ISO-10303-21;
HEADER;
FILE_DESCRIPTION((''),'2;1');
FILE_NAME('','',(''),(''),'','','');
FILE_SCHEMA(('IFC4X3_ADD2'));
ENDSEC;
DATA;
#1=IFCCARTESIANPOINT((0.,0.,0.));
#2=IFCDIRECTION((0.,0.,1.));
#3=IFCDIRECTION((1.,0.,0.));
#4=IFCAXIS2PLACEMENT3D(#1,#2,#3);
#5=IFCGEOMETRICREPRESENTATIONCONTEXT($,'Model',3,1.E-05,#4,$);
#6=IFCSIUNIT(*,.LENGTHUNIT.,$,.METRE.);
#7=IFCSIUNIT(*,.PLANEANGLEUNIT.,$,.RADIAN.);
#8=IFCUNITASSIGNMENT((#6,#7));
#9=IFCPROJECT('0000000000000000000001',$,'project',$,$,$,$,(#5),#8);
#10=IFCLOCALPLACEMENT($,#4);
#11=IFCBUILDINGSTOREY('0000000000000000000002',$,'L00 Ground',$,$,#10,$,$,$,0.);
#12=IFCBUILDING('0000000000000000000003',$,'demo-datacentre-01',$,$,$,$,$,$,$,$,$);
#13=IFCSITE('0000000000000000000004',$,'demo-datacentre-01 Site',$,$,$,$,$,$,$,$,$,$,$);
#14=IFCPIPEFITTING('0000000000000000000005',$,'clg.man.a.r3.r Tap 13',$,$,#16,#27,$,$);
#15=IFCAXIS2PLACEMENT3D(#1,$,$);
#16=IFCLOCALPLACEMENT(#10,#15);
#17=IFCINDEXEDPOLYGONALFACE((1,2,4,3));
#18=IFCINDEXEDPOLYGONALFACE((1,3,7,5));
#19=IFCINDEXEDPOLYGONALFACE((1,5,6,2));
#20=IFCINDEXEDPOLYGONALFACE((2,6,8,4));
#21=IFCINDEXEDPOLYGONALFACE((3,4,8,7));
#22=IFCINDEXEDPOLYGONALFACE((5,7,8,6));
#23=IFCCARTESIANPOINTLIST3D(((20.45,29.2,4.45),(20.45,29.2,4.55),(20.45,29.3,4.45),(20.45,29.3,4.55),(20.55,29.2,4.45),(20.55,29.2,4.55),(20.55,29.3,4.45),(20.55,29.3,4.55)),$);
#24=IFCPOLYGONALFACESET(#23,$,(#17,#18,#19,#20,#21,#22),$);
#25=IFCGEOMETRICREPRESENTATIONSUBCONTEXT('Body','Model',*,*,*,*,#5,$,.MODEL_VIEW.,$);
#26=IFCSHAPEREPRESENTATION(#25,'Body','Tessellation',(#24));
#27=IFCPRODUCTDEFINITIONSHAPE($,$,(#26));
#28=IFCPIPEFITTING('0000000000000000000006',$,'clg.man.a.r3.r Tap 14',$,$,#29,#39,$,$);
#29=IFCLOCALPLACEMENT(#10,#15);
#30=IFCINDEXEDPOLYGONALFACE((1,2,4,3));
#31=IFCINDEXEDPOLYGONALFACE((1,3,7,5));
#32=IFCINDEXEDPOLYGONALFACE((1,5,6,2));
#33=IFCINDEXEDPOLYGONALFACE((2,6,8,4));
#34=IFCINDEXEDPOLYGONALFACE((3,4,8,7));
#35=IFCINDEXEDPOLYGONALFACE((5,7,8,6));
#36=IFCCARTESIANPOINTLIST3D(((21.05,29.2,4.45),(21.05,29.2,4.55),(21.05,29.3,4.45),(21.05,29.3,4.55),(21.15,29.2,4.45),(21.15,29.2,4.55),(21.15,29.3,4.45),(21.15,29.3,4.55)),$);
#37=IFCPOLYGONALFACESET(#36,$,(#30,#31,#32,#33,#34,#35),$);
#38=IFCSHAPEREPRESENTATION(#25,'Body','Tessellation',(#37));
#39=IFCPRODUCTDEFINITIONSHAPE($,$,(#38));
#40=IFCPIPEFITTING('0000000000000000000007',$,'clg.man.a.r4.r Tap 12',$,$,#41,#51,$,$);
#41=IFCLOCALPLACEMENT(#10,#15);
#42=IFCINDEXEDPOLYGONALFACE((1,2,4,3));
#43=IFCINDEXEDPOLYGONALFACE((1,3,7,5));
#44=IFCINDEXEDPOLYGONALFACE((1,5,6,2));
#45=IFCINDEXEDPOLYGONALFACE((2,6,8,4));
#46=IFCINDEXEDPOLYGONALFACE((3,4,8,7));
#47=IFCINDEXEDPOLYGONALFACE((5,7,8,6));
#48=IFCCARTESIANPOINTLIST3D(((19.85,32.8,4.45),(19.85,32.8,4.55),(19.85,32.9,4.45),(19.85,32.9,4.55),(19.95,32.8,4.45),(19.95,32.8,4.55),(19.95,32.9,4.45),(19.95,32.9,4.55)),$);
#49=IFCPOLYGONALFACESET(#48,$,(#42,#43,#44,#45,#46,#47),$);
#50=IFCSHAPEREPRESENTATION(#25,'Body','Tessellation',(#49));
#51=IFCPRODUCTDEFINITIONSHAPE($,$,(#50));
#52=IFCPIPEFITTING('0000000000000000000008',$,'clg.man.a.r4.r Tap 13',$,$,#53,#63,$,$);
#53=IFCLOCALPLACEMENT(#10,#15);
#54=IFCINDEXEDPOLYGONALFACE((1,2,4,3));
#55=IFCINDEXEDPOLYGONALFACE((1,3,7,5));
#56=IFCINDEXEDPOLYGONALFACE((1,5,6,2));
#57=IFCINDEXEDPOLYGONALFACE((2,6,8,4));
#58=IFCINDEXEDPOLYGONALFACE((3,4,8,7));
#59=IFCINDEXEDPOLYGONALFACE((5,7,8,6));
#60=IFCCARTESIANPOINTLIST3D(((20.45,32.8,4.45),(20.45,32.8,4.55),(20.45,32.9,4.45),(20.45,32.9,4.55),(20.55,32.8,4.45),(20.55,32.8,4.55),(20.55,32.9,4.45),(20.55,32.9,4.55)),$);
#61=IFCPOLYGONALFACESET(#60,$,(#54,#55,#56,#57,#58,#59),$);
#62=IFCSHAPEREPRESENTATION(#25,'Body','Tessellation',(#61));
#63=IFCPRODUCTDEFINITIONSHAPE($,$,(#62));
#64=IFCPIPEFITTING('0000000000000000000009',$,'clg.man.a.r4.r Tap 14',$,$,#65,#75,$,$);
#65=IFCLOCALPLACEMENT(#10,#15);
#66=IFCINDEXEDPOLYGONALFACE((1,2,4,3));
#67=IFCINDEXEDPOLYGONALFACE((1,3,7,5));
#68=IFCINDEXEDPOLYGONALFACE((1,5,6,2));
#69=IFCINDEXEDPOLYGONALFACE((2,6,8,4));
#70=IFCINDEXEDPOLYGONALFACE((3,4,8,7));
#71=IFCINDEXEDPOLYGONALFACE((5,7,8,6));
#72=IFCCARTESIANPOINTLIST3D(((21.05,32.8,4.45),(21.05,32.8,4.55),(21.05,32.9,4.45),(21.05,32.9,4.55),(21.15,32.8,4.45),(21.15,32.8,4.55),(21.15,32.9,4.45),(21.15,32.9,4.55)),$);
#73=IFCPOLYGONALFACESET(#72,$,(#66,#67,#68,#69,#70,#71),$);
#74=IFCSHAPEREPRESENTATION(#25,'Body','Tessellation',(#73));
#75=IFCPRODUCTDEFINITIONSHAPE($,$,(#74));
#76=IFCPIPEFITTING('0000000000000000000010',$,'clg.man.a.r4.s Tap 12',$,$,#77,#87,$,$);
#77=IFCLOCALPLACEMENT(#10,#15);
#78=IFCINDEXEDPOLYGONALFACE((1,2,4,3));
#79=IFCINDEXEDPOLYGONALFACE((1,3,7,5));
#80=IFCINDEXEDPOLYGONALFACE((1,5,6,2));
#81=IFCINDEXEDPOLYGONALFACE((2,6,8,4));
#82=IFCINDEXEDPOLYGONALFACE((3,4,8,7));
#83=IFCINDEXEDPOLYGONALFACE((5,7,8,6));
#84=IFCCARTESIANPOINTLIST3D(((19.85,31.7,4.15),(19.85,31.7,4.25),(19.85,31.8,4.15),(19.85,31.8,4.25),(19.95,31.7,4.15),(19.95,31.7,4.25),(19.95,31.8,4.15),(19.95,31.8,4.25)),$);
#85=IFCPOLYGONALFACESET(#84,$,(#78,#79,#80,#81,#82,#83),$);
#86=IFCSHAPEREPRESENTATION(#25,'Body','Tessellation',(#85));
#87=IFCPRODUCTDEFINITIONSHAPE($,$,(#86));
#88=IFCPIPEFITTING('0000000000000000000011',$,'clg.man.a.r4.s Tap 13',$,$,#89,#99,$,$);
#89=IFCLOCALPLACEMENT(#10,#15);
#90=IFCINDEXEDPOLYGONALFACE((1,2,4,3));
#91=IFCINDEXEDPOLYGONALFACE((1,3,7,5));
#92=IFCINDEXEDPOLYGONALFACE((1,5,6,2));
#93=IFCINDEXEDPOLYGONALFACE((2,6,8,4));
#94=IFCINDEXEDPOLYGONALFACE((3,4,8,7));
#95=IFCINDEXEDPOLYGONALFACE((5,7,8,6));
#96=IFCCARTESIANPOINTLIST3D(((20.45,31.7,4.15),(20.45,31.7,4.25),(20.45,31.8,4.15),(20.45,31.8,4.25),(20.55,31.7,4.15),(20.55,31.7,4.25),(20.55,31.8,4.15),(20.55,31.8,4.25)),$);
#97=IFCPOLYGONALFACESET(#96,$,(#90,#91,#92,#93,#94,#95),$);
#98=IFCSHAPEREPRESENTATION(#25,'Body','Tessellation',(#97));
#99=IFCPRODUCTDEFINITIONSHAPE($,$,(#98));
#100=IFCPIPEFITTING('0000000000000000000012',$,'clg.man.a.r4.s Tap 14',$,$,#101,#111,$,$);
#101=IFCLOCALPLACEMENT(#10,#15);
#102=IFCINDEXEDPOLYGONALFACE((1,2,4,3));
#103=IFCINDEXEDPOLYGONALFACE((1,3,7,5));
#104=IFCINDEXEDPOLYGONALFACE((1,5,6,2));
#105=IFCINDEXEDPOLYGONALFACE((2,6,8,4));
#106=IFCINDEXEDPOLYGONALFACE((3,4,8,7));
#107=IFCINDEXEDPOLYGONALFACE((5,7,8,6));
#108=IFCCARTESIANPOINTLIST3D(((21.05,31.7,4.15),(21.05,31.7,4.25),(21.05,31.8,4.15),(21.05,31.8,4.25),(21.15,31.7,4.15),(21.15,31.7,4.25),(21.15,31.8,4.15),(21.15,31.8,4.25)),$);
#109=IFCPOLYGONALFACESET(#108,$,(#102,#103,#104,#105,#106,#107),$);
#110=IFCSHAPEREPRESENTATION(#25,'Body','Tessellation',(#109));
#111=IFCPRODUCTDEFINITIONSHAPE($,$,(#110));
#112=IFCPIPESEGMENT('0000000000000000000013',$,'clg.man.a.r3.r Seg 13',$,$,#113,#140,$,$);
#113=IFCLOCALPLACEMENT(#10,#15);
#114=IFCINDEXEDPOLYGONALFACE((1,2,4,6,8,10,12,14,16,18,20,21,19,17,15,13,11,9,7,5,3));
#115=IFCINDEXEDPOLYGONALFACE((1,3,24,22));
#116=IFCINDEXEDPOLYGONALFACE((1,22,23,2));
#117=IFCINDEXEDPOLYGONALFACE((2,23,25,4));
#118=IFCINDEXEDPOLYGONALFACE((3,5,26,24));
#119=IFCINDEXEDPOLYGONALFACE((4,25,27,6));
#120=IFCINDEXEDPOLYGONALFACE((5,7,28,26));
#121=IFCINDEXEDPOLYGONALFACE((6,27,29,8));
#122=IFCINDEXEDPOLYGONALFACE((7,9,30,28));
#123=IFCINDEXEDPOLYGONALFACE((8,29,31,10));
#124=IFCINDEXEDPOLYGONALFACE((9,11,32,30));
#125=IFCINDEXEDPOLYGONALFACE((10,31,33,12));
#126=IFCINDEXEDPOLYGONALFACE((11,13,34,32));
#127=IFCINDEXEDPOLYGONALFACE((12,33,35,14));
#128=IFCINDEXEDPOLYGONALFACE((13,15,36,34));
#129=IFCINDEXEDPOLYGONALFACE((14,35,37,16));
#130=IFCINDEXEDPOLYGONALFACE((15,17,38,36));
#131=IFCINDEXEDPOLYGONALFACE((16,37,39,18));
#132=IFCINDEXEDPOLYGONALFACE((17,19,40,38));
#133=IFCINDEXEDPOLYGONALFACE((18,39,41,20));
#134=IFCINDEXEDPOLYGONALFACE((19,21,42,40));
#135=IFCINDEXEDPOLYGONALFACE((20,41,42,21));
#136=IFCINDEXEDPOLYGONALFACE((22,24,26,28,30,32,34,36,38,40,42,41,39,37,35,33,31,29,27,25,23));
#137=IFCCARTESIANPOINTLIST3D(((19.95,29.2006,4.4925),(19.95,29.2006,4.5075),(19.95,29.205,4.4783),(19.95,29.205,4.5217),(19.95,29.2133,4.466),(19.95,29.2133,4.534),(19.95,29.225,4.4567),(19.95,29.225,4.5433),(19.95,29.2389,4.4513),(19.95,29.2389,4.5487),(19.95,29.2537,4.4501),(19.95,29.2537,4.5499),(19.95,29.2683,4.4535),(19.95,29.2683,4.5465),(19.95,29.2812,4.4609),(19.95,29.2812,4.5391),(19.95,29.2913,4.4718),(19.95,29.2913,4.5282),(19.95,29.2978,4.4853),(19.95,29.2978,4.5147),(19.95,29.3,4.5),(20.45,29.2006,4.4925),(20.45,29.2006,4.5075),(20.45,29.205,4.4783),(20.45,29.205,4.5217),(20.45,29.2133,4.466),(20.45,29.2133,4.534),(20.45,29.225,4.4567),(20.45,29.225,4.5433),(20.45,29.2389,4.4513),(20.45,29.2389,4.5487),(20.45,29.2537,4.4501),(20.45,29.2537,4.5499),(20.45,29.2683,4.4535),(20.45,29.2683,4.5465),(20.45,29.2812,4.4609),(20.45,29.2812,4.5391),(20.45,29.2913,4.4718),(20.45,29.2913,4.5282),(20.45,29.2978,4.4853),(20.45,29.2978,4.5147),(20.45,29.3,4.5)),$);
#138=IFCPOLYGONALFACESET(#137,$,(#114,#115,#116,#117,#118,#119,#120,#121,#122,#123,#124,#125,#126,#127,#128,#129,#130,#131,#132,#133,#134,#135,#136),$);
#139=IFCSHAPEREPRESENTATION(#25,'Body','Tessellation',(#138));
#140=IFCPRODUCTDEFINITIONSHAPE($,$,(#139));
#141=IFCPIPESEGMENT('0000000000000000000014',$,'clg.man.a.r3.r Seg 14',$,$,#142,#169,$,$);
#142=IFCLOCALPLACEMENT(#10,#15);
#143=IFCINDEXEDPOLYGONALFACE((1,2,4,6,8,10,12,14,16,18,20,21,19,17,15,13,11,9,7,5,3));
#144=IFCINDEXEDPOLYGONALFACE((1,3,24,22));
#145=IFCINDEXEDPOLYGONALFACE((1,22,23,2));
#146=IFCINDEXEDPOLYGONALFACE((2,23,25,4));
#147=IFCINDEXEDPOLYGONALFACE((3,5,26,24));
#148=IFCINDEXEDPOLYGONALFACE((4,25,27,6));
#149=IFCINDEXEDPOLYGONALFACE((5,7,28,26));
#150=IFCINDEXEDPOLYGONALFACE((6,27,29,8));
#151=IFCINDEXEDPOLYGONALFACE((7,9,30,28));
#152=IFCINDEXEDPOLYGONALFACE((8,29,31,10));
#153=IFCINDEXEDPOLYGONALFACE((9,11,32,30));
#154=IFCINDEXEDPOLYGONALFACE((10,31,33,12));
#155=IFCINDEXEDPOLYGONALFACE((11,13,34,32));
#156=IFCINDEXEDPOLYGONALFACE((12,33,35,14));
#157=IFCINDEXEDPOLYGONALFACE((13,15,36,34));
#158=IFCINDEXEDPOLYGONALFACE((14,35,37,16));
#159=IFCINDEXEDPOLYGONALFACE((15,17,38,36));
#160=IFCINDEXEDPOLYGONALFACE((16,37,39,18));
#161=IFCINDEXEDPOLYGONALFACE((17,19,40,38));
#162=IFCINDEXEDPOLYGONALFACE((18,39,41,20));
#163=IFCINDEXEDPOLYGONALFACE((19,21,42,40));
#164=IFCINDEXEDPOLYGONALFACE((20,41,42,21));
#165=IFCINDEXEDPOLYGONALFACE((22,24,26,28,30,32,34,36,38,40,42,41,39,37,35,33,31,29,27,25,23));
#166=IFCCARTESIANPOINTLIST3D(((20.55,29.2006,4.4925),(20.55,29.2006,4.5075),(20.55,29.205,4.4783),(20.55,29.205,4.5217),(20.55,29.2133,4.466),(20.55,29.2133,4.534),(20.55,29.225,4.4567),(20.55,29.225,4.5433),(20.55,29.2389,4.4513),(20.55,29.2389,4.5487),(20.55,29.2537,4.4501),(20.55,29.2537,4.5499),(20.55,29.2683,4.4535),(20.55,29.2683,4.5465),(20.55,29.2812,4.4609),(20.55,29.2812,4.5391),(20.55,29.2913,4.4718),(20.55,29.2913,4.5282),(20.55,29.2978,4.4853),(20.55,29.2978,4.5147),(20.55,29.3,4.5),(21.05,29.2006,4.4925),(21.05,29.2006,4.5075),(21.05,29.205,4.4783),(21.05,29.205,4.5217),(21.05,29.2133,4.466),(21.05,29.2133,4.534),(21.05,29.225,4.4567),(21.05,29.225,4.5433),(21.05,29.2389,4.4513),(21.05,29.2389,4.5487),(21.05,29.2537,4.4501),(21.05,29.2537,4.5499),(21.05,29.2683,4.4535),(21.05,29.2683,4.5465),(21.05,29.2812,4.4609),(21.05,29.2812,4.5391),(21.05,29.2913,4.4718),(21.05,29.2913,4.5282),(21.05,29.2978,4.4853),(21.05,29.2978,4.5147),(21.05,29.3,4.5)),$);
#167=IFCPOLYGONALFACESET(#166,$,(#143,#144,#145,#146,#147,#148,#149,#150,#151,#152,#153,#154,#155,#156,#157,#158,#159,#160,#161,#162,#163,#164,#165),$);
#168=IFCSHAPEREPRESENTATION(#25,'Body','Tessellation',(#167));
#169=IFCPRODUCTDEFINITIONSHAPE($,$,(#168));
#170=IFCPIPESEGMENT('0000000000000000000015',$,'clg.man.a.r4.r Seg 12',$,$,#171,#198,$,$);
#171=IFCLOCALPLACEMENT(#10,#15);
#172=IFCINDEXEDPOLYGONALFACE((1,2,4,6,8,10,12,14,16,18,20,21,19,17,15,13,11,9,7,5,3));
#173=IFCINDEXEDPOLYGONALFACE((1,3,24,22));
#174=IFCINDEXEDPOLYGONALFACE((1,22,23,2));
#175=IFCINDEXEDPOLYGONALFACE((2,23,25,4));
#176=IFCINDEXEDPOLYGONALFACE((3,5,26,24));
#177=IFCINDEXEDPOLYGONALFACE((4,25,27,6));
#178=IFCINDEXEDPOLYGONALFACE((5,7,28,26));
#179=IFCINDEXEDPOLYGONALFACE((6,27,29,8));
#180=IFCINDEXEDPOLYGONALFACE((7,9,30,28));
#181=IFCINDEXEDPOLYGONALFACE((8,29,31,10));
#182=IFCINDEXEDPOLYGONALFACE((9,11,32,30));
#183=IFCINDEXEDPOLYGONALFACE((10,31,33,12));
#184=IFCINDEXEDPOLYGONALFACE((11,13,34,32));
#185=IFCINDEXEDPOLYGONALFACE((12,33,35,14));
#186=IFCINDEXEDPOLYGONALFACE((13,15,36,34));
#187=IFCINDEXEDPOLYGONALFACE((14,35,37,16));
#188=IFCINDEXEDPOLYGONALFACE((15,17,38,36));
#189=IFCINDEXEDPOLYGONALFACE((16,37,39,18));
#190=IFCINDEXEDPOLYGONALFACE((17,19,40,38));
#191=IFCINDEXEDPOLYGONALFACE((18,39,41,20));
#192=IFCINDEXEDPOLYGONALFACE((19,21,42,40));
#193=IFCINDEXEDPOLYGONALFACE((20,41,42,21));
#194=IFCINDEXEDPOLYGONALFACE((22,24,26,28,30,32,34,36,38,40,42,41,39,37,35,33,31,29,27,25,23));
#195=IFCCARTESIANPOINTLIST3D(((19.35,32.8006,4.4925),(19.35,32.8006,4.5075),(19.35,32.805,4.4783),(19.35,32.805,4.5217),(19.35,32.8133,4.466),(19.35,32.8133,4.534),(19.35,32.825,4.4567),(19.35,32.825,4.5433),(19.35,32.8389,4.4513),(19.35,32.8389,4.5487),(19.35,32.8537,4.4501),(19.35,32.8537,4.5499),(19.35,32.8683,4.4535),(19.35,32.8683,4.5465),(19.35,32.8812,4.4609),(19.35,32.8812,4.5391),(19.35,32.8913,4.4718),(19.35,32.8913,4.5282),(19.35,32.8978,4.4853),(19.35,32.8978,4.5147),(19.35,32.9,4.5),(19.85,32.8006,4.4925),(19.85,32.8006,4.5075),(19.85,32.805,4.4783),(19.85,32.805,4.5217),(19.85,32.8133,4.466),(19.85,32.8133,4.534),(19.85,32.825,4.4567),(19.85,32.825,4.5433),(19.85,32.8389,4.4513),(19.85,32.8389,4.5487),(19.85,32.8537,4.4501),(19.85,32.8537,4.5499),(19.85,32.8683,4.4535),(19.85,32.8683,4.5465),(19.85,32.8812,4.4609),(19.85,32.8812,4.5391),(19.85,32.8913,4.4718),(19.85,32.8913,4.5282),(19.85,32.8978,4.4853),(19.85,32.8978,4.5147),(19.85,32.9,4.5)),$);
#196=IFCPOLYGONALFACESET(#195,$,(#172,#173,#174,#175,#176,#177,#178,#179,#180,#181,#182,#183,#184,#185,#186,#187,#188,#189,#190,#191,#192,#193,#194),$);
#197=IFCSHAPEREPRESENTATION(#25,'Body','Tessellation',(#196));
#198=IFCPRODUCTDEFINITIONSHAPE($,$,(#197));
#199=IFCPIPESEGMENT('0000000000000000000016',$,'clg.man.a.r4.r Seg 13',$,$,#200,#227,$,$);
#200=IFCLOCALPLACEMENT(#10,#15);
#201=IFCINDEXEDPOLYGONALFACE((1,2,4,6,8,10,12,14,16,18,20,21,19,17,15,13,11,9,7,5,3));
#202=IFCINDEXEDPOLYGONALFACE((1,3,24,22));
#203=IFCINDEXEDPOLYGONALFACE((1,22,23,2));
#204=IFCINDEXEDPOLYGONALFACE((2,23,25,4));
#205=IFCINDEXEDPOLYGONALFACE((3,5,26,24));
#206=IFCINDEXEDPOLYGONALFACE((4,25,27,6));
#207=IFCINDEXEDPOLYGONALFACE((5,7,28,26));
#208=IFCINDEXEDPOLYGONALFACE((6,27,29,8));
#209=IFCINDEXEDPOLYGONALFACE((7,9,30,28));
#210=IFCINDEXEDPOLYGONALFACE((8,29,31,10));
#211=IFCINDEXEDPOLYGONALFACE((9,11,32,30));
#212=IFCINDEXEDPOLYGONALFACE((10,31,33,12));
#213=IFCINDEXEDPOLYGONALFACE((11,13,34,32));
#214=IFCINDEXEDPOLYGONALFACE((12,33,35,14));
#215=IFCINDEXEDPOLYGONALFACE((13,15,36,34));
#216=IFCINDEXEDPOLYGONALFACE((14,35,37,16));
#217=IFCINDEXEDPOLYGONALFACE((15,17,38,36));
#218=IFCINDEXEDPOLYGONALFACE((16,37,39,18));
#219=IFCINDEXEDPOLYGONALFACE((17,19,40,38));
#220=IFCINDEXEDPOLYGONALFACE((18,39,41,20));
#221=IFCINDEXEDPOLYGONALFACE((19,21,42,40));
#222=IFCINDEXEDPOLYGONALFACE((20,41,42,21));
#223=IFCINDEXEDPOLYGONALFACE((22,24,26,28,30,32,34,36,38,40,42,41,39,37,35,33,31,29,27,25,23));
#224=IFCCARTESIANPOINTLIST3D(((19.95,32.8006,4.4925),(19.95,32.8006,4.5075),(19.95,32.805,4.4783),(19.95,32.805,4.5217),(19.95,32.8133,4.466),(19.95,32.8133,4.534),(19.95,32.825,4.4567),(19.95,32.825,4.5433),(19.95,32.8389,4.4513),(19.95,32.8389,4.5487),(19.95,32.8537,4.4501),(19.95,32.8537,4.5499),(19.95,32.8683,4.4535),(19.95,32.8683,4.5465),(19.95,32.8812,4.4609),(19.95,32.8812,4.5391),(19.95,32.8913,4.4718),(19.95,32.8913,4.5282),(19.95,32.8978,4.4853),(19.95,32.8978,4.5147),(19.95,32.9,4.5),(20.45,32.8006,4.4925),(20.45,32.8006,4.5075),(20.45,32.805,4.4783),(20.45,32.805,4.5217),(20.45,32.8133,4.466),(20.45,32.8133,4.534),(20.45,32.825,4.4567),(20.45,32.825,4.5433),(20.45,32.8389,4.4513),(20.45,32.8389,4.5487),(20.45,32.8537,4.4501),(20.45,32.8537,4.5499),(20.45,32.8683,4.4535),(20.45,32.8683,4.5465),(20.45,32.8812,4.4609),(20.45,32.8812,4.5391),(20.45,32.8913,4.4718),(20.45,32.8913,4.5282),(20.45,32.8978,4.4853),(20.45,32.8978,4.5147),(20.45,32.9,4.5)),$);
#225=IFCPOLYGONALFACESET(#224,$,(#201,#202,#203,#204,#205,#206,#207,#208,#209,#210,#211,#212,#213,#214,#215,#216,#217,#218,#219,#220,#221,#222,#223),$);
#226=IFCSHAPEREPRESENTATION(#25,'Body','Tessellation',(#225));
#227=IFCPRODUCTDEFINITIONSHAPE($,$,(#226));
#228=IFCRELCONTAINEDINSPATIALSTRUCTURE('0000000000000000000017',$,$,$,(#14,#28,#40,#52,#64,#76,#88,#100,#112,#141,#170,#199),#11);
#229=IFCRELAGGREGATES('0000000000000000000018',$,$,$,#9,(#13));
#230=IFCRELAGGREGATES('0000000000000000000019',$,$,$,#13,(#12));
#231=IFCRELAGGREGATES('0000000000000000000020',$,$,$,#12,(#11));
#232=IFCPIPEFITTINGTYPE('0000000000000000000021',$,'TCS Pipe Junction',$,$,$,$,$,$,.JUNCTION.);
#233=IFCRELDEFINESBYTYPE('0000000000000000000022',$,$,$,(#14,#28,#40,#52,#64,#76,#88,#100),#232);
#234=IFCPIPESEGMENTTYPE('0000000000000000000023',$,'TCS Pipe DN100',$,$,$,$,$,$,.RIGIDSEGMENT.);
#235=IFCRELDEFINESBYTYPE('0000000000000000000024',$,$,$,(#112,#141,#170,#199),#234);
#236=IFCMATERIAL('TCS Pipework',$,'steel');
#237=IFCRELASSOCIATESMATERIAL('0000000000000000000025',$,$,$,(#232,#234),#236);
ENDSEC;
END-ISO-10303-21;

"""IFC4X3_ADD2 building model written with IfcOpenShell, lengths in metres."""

from ifc_helpers import new_model, si_unit, frame, origin_with_axes, place, context, subcontext, project, spatial, rectangle, circle, extrude, material, type_object, element, save


model = new_model("IFC4X3_ADD2")

# Units and contexts
model_context = context("Model", 3, precision=1e-05, world=origin_with_axes())
body_context = subcontext(model_context, "Body", "Model", "MODEL_VIEW")
ifc_project = project(units=[si_unit("LENGTHUNIT", "METRE"), si_unit("PLANEANGLEUNIT", "RADIAN")], contexts=[model_context])

# Site, building, storey
site = spatial("IfcSite", under=ifc_project, Name="demo-datacentre-01 Site")
building = spatial("IfcBuilding", under=site, Name="demo-datacentre-01")
storey_placement = place(None, origin_with_axes())
storey = spatial("IfcBuildingStorey", under=building, at=storey_placement, Name="L00 Ground", Elevation=0.0)

# Pipe fittings
ifc_material = material(Name="TCS Pipework", Category="steel")
pipe_fitting_type = type_object("IfcPipeFittingType", Name="TCS Pipe Junction", PredefinedType="JUNCTION", material=ifc_material)
for number, where, z_axis, x_axis, name in (
    (1, (20.5, 29.25, 4.45), (0.0, 0.0, 1.0), (1.0, 0.0, 0.0), "clg.man.a.r3.r Tap 13"),
    (2, (21.1, 29.25, 4.45), (0.0, 0.0, 1.0), (1.0, 0.0, 0.0), "clg.man.a.r3.r Tap 14"),
    (3, (19.9, 32.85, 4.45), (0.0, 0.0, 1.0), (1.0, 0.0, 0.0), "clg.man.a.r4.r Tap 12"),
    (4, (20.5, 32.85, 4.45), (0.0, 0.0, 1.0), (1.0, 0.0, 0.0), "clg.man.a.r4.r Tap 13"),
    (5, (21.1, 32.85, 4.45), (0.0, 0.0, 1.0), (1.0, 0.0, 0.0), "clg.man.a.r4.r Tap 14"),
    (6, (19.9, 31.75, 4.15), (0.0, 0.0, 1.0), (1.0, 0.0, 0.0), "clg.man.a.r4.s Tap 12"),
    (7, (20.5, 31.75, 4.15), (0.0, 0.0, 1.0), (1.0, 0.0, 0.0), "clg.man.a.r4.s Tap 13"),
    (8, (21.1, 31.75, 4.15), (0.0, 0.0, 1.0), (1.0, 0.0, 0.0), "clg.man.a.r4.s Tap 14"),
):
    element("IfcPipeFitting", number, at=place(storey_placement, frame(where, z_axis=z_axis, x_axis=x_axis)), inside=storey, type_object=pipe_fitting_type, Name=name, context=body_context, shape_type="SweptSolid", body=[
        extrude(rectangle(XDim=0.1, YDim=0.1), origin_with_axes(), (0.0, 0.0, 1.0), 0.1),
    ])

# Pipe segments
pipe_segment_type_1 = type_object("IfcPipeSegmentType", Name="TCS Pipe DN100", PredefinedType="RIGIDSEGMENT", material=ifc_material)
for number, where, z_axis, x_axis, name in (
    (9, (19.95, 29.25, 4.5), (1.0, 0.0, 0.0), (0.0, 1.0, 0.0), "clg.man.a.r3.r Seg 13"),
    (10, (20.55, 29.25, 4.5), (1.0, 0.0, 0.0), (0.0, 1.0, 0.0), "clg.man.a.r3.r Seg 14"),
):
    element("IfcPipeSegment", number, at=place(storey_placement, frame(where, z_axis=z_axis, x_axis=x_axis)), inside=storey, type_object=pipe_segment_type_1, Name=name, context=body_context, shape_type="SweptSolid", body=[
        extrude(circle(Radius=0.05), origin_with_axes(), (0.0, 0.0, 1.0), 0.5),
    ])
pipe_segment_placement = place(storey_placement, frame((19.35, 32.85, 4.5), z_axis=(1.0, 0.0, 0.0), x_axis=(0.0, 1.0, 0.0)))
element("IfcPipeSegment", 11, at=pipe_segment_placement, inside=storey, type_object=pipe_segment_type_1, Name="clg.man.a.r4.r Seg 12", context=body_context, shape_type="SweptSolid", body=[
    extrude(circle(Radius=0.05), origin_with_axes(), (0.0, 0.0, 1.0), 0.5),
])
for number, where, z_axis, x_axis, name in (
    (12, (19.95, 32.85, 4.5), (1.0, 0.0, 0.0), (0.0, 1.0, 0.0), "clg.man.a.r4.r Seg 13"),
):
    element("IfcPipeSegment", number, at=place(storey_placement, frame(where, z_axis=z_axis, x_axis=x_axis)), inside=storey, type_object=pipe_segment_type_1, Name=name, context=body_context, shape_type="SweptSolid", body=[
        extrude(circle(Radius=0.05), origin_with_axes(), (0.0, 0.0, 1.0), 0.5),
    ])

save(model, "model.ifc")
